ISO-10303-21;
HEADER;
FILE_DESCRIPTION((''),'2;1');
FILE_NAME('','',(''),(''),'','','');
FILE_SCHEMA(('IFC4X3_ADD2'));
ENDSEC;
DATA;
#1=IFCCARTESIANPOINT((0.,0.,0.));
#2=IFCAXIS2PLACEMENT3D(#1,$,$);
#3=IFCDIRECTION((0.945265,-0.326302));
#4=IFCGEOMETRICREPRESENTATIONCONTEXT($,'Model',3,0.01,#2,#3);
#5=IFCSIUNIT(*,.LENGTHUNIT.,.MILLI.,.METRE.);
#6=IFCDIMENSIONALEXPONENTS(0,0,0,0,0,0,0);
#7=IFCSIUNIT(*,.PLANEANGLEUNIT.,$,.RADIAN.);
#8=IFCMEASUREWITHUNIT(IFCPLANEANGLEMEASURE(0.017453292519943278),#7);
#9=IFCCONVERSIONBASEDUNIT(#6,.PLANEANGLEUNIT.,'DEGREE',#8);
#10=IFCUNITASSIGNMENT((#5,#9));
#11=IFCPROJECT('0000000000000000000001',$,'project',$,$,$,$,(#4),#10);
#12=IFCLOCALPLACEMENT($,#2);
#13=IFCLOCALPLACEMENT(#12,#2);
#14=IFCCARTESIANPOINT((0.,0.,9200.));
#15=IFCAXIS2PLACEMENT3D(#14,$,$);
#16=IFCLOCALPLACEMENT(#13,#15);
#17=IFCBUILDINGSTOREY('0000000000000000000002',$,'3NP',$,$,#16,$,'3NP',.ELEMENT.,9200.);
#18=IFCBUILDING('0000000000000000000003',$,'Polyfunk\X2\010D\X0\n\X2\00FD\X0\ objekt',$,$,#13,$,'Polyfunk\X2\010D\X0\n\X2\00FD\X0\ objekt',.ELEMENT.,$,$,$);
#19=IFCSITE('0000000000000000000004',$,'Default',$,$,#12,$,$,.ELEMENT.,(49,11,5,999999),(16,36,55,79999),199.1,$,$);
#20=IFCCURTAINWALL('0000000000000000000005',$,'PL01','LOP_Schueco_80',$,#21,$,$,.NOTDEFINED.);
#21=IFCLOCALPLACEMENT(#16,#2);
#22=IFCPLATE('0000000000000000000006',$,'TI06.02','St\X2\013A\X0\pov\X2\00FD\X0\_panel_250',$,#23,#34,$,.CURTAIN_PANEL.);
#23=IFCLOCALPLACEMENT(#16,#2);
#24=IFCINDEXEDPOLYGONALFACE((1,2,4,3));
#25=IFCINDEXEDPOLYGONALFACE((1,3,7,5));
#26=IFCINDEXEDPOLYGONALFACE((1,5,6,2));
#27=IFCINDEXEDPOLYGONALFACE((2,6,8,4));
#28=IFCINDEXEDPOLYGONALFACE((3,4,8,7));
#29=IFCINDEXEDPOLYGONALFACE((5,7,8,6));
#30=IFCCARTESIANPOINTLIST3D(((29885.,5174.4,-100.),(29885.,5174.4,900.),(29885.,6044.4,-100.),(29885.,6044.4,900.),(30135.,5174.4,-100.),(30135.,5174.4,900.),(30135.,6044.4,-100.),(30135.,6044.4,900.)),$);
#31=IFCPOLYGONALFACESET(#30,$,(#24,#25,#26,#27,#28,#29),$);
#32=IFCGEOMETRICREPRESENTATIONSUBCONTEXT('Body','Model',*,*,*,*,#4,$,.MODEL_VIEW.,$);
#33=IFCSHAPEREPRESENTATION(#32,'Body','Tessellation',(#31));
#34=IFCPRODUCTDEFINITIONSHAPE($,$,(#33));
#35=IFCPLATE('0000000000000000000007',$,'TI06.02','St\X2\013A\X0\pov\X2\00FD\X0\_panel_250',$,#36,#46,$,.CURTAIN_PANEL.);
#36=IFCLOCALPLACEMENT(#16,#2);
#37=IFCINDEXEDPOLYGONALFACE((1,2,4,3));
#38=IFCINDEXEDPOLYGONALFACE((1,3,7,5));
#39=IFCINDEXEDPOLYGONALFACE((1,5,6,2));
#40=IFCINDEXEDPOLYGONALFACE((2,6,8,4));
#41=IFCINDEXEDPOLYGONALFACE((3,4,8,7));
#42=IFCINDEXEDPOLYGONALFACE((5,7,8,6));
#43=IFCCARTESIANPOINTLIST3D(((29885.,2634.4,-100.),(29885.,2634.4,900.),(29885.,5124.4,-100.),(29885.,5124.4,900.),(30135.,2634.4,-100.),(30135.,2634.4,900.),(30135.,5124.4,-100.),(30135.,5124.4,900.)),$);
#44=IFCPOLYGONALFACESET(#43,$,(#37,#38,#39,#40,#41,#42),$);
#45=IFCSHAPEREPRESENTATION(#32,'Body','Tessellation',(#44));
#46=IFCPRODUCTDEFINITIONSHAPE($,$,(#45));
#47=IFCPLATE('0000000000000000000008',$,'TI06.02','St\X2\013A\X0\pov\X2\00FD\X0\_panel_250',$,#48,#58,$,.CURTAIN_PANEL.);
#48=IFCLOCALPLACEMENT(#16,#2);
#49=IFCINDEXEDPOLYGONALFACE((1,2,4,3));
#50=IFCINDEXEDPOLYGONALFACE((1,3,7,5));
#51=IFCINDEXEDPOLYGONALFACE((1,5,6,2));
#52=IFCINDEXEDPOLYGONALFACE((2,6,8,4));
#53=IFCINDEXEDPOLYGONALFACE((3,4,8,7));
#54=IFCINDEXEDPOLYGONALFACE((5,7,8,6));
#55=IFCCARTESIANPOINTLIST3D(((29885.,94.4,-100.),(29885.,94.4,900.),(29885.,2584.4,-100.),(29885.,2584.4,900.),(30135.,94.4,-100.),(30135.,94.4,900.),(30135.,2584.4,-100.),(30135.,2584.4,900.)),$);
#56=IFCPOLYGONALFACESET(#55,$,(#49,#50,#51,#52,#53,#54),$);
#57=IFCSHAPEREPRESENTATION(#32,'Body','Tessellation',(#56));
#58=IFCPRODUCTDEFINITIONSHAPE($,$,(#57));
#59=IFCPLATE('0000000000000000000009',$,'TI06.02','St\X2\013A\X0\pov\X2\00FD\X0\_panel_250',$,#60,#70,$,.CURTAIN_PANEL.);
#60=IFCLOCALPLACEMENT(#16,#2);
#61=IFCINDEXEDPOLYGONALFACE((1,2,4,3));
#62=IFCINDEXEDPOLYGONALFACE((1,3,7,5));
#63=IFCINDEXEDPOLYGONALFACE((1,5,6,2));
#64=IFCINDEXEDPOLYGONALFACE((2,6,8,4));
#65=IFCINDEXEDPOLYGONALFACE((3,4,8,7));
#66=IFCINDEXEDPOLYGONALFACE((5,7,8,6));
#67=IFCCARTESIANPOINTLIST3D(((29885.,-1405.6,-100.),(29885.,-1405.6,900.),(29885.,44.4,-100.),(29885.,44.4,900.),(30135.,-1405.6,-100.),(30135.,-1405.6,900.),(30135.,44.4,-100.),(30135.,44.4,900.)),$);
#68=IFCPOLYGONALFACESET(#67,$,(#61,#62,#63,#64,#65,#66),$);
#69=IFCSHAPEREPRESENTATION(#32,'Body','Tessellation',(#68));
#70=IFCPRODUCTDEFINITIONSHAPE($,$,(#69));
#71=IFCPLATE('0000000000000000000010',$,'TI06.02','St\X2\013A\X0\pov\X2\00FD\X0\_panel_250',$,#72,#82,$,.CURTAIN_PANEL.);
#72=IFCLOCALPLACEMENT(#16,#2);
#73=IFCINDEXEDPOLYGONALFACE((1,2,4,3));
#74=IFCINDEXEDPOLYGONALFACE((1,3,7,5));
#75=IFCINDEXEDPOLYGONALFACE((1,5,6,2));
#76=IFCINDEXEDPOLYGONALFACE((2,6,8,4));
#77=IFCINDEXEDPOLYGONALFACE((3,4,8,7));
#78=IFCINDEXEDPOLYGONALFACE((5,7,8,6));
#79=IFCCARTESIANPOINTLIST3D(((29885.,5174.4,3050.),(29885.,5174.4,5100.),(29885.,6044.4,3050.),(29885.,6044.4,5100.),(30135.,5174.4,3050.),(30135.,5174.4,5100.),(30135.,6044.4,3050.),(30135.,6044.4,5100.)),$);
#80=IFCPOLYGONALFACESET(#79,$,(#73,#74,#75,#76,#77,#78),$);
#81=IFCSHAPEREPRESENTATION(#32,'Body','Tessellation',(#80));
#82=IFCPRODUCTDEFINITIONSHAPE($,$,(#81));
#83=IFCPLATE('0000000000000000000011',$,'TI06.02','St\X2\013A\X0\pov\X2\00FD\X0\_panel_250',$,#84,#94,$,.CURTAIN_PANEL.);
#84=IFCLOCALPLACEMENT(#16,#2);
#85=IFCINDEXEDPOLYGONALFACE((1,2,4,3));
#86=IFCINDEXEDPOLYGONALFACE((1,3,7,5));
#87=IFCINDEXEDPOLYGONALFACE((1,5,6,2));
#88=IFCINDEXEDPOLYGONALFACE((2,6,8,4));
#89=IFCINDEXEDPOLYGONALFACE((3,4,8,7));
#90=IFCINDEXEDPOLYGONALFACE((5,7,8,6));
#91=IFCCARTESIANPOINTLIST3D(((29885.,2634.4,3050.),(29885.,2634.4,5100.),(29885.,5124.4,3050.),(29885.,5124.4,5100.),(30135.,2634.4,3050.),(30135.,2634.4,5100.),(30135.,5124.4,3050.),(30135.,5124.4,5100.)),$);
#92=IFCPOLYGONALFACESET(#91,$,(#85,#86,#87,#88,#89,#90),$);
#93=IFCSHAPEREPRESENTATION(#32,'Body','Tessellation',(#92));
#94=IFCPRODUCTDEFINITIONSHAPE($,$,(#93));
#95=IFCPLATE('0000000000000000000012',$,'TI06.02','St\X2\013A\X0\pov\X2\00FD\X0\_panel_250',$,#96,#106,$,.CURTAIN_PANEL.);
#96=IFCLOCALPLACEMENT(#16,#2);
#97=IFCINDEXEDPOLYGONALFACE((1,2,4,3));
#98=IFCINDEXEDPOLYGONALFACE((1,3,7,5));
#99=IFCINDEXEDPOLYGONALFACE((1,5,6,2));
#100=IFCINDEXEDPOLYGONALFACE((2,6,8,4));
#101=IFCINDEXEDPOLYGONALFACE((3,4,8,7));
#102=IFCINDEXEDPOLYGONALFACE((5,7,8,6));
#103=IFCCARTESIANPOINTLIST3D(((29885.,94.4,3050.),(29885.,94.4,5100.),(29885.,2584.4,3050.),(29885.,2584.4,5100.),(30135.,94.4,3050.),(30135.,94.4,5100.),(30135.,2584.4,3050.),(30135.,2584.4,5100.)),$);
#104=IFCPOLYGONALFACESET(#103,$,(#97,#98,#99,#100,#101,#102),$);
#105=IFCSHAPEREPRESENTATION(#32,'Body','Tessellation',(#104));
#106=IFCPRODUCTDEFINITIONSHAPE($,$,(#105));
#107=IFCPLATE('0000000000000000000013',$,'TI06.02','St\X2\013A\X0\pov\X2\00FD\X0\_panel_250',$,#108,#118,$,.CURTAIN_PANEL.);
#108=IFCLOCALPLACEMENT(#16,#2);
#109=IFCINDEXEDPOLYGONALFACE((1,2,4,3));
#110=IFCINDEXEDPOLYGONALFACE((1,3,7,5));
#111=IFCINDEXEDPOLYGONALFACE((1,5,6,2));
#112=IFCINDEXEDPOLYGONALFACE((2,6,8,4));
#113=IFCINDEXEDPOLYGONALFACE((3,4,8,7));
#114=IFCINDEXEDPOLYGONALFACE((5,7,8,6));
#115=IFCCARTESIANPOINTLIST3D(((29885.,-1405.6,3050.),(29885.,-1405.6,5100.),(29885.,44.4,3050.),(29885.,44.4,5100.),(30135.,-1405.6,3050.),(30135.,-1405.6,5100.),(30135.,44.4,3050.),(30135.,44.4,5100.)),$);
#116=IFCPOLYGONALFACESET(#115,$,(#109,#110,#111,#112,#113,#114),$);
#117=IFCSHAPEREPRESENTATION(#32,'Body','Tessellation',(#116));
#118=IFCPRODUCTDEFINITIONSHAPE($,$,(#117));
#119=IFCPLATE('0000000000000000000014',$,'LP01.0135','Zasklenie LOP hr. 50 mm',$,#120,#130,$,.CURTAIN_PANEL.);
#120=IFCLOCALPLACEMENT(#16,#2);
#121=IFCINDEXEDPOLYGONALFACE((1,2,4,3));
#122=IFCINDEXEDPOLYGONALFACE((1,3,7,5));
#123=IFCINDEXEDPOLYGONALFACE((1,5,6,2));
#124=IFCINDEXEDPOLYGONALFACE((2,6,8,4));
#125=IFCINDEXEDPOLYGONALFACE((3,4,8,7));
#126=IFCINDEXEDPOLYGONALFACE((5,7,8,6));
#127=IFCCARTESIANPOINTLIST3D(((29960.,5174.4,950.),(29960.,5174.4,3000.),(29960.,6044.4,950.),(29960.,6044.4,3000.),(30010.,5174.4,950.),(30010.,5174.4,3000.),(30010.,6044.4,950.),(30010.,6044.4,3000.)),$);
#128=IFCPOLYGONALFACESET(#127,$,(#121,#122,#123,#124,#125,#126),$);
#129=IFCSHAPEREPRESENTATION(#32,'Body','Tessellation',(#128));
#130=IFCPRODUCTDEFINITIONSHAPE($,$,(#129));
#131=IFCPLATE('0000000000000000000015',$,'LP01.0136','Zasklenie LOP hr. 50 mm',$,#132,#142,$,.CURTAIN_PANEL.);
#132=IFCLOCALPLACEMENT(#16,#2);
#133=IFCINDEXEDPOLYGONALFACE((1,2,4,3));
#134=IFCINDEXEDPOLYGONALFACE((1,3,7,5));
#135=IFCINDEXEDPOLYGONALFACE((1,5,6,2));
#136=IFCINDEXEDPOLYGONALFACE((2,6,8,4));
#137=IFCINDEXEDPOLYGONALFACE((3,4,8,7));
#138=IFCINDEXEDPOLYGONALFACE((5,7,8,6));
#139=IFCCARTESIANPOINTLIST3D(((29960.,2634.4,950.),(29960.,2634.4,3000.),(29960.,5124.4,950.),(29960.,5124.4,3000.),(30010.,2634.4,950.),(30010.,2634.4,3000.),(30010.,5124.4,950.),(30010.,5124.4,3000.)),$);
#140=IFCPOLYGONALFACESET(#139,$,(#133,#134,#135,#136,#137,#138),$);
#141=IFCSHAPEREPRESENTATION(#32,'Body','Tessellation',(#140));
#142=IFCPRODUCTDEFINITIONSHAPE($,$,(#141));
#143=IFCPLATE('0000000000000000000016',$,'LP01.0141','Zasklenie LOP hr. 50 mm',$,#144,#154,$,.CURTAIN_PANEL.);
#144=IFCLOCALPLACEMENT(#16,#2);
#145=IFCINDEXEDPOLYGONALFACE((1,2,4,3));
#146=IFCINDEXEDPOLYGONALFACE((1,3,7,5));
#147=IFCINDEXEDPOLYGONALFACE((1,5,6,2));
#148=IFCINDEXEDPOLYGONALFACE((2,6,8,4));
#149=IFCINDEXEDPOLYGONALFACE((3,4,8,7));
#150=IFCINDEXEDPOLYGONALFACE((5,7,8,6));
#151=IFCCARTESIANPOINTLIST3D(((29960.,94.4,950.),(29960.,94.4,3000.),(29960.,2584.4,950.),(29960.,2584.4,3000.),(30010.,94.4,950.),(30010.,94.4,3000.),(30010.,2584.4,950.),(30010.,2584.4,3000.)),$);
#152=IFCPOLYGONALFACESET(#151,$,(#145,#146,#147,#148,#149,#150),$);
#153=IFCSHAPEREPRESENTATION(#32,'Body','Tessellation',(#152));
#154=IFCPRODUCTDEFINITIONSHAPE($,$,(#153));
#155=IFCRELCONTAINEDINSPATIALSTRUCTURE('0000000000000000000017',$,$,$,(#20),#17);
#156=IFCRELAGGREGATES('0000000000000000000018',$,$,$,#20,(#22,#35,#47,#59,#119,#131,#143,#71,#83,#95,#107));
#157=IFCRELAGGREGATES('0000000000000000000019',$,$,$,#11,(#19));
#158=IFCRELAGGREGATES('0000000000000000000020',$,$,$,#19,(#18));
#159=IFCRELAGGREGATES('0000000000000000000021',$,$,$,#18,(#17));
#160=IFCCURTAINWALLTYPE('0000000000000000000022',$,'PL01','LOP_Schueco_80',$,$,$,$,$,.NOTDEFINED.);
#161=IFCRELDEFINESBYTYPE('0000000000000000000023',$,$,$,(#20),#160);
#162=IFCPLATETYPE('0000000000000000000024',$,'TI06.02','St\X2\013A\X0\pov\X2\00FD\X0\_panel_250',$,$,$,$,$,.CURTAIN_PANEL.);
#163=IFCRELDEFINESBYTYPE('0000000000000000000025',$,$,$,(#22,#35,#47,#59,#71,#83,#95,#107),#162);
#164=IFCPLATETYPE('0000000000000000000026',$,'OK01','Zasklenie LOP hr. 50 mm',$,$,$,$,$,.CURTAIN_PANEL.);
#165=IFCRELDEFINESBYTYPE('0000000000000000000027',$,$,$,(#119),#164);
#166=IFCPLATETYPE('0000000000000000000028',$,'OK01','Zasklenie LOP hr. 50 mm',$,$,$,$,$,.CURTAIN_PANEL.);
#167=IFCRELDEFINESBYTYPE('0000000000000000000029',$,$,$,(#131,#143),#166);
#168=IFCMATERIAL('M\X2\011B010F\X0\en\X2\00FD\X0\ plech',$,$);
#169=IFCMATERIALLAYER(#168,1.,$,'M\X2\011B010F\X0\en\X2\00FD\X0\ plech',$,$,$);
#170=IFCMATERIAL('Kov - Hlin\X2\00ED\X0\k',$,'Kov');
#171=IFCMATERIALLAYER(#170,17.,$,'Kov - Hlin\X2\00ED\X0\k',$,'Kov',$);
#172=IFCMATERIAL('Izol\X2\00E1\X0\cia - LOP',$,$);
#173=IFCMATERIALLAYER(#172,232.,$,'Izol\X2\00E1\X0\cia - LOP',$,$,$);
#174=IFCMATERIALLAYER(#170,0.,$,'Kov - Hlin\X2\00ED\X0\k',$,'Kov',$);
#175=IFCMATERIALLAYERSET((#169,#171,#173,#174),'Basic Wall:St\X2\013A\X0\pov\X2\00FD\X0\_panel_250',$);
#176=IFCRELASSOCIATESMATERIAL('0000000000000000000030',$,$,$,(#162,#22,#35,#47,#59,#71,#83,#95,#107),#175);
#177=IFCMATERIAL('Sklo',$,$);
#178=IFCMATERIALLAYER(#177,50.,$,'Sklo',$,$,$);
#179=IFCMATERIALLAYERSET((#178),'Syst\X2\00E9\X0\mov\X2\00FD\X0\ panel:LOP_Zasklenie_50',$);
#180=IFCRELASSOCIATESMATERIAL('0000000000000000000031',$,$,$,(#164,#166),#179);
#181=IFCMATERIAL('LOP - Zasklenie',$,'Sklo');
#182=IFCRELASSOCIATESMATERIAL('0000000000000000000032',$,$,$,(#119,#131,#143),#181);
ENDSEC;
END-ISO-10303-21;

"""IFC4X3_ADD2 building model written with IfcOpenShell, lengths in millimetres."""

from ifc_helpers import new_model, entity, si_unit, converted_unit, direction, frame, frame_2d, origin, origin_2d_with_axis, place, context, subcontext, project, spatial, rectangle, extrude, source, transform, mapped, material, layer, layer_set, layer_usage, type_object, type_shapes, element, aggregate, save


model = new_model("IFC4X3_ADD2")

# Units and contexts
model_context = context("Model", 3, precision=0.01, world=origin(), true_north=direction((0.945265, -0.326302)))
body_context = subcontext(model_context, "Body", "Model", "MODEL_VIEW")
ifc_project = project(units=[si_unit("LENGTHUNIT", "METRE", prefix="MILLI"), converted_unit("PLANEANGLEUNIT", "DEGREE", entity("IfcPlaneAngleMeasure", 0.017453292519943278), si_unit("PLANEANGLEUNIT", "RADIAN"), dimensions=[0, 0, 0, 0, 0, 0, 0])], contexts=[model_context])

# Site, building, storey
site_placement = place(None, origin())
site = spatial("IfcSite", under=ifc_project, at=site_placement, Name="Default", CompositionType="ELEMENT", RefLatitude=(49, 11, 5, 999999), RefLongitude=(16, 36, 55, 79999), RefElevation=199.1)
building_placement = place(site_placement, origin())
building = spatial("IfcBuilding", under=site, at=building_placement, Name="Polyfunkčný objekt", LongName="Polyfunkčný objekt", CompositionType="ELEMENT")
storey_placement = place(building_placement, frame((0.0, 0.0, 9200.0)))
storey = spatial("IfcBuildingStorey", under=building, at=storey_placement, Name="3NP", LongName="3NP", CompositionType="ELEMENT", Elevation=9200.0)

# Curtain wall
curtain_wall_type = type_object("IfcCurtainWallType", Name="PL01", Description="LOP_Schueco_80", PredefinedType="NOTDEFINED")
curtain_wall_1_placement = place(storey_placement, frame((0.0, 0.0, -9200.0)))
curtain_wall_1 = element("IfcCurtainWall", 1, at=curtain_wall_1_placement, inside=storey, type_object=curtain_wall_type, Name="PL01", Description="LOP_Schueco_80", PredefinedType="NOTDEFINED")

# Plates
ifc_material_1 = material(Name="Měďený plech")
ifc_layer_1 = layer(ifc_material_1, 1.0, Name="Měďený plech")
ifc_material_2 = material(Name="Kov - Hliník", Category="Kov")
ifc_layer_2 = layer(ifc_material_2, 17.0, Name="Kov - Hliník", Category="Kov")
ifc_material_3 = material(Name="Izolácia - LOP")
ifc_layer_3 = layer(ifc_material_3, 232.0, Name="Izolácia - LOP")
ifc_layer_4 = layer(ifc_material_2, 0.0, Name="Kov - Hliník", Category="Kov")
ifc_layer_set_1 = layer_set([ifc_layer_1, ifc_layer_2, ifc_layer_3, ifc_layer_4], Name="Basic Wall:Stĺpový_panel_250")
ifc_layer_usage_1 = layer_usage(ifc_layer_set_1, "AXIS2", "POSITIVE", -125.0)
plate_type_1 = type_object("IfcPlateType", Name="TI06.02", Description="Stĺpový_panel_250", PredefinedType="CURTAIN_PANEL", material=ifc_layer_set_1)
plate_1_placement = place(storey_placement, frame((30010.0, 6044.4, -100.0), z_axis=(0.0, 0.0, 1.0), x_axis=(0.0, -1.0, 0.0)))
plate_1 = element("IfcPlate", 2, at=plate_1_placement, type_object=plate_type_1, material=ifc_layer_usage_1, Name="TI06.02", Description="Stĺpový_panel_250", PredefinedType="CURTAIN_PANEL", context=body_context, shape_type="SweptSolid", body=[
    extrude(rectangle(XDim=250.0, YDim=870.0, at=frame_2d((0.0, 0.0), x_axis=(1.0, 0.0))), frame((435.0, 0.0, 0.0), z_axis=(0.0, 0.0, 1.0), x_axis=(0.0, 1.0, 0.0)), (0.0, 0.0, 1.0), 1000.0),
])
ifc_layer_usage_2 = layer_usage(ifc_layer_set_1, "AXIS2", "POSITIVE", -125.0)
plate_2_placement = place(storey_placement, frame((30010.0, 5124.4, -100.0), z_axis=(0.0, 0.0, 1.0), x_axis=(0.0, -1.0, 0.0)))
plate_2 = element("IfcPlate", 3, at=plate_2_placement, type_object=plate_type_1, material=ifc_layer_usage_2, Name="TI06.02", Description="Stĺpový_panel_250", PredefinedType="CURTAIN_PANEL", context=body_context, shape_type="SweptSolid", body=[
    extrude(rectangle(XDim=250.0, YDim=2490.0, at=frame_2d((0.0, 0.0), x_axis=(1.0, 0.0))), frame((1245.0, 0.0, 0.0), z_axis=(0.0, 0.0, 1.0), x_axis=(0.0, 1.0, 0.0)), (0.0, 0.0, 1.0), 1000.0),
])
ifc_layer_usage_3 = layer_usage(ifc_layer_set_1, "AXIS2", "POSITIVE", -125.0)
plate_3_placement = place(storey_placement, frame((30010.0, 2584.4, -100.0), z_axis=(0.0, 0.0, 1.0), x_axis=(0.0, -1.0, 0.0)))
plate_3 = element("IfcPlate", 4, at=plate_3_placement, type_object=plate_type_1, material=ifc_layer_usage_3, Name="TI06.02", Description="Stĺpový_panel_250", PredefinedType="CURTAIN_PANEL", context=body_context, shape_type="SweptSolid", body=[
    extrude(rectangle(XDim=250.0, YDim=2490.0, at=frame_2d((0.0, 0.0), x_axis=(1.0, 0.0))), frame((1245.0, 0.0, 0.0), z_axis=(0.0, 0.0, 1.0), x_axis=(0.0, 1.0, 0.0)), (0.0, 0.0, 1.0), 1000.0),
])
ifc_layer_usage_4 = layer_usage(ifc_layer_set_1, "AXIS2", "POSITIVE", -125.0)
plate_4_placement = place(storey_placement, frame((30010.0, 44.4, -100.0), z_axis=(0.0, 0.0, 1.0), x_axis=(0.0, -1.0, 0.0)))
plate_4 = element("IfcPlate", 5, at=plate_4_placement, type_object=plate_type_1, material=ifc_layer_usage_4, Name="TI06.02", Description="Stĺpový_panel_250", PredefinedType="CURTAIN_PANEL", context=body_context, shape_type="SweptSolid", body=[
    extrude(rectangle(XDim=250.0, YDim=1450.0, at=frame_2d((0.0, 0.0), x_axis=(1.0, 0.0))), frame((725.0, 0.0, 0.0), z_axis=(0.0, 0.0, 1.0), x_axis=(0.0, 1.0, 0.0)), (0.0, 0.0, 1.0), 1000.0),
])
ifc_layer_usage_5 = layer_usage(ifc_layer_set_1, "AXIS2", "POSITIVE", -125.0)
plate_5_placement = place(storey_placement, frame((30010.0, 6044.4, 3050.0), z_axis=(0.0, 0.0, 1.0), x_axis=(0.0, -1.0, 0.0)))
plate_5 = element("IfcPlate", 6, at=plate_5_placement, type_object=plate_type_1, material=ifc_layer_usage_5, Name="TI06.02", Description="Stĺpový_panel_250", PredefinedType="CURTAIN_PANEL", context=body_context, shape_type="SweptSolid", body=[
    extrude(rectangle(XDim=250.0, YDim=870.0, at=frame_2d((0.0, 0.0), x_axis=(1.0, 0.0))), frame((435.0, 0.0, 0.0), z_axis=(0.0, 0.0, 1.0), x_axis=(0.0, 1.0, 0.0)), (0.0, 0.0, 1.0), 2050.0),
])
ifc_layer_usage_6 = layer_usage(ifc_layer_set_1, "AXIS2", "POSITIVE", -125.0)
plate_6_placement = place(storey_placement, frame((30010.0, 5124.4, 3050.0), z_axis=(0.0, 0.0, 1.0), x_axis=(0.0, -1.0, 0.0)))
plate_6 = element("IfcPlate", 7, at=plate_6_placement, type_object=plate_type_1, material=ifc_layer_usage_6, Name="TI06.02", Description="Stĺpový_panel_250", PredefinedType="CURTAIN_PANEL", context=body_context, shape_type="SweptSolid", body=[
    extrude(rectangle(XDim=250.0, YDim=2490.0, at=frame_2d((0.0, 0.0), x_axis=(1.0, 0.0))), frame((1245.0, 0.0, 0.0), z_axis=(0.0, 0.0, 1.0), x_axis=(0.0, 1.0, 0.0)), (0.0, 0.0, 1.0), 2050.0),
])
ifc_layer_usage_7 = layer_usage(ifc_layer_set_1, "AXIS2", "POSITIVE", -125.0)
plate_7_placement = place(storey_placement, frame((30010.0, 2584.4, 3050.0), z_axis=(0.0, 0.0, 1.0), x_axis=(0.0, -1.0, 0.0)))
plate_7 = element("IfcPlate", 8, at=plate_7_placement, type_object=plate_type_1, material=ifc_layer_usage_7, Name="TI06.02", Description="Stĺpový_panel_250", PredefinedType="CURTAIN_PANEL", context=body_context, shape_type="SweptSolid", body=[
    extrude(rectangle(XDim=250.0, YDim=2490.0, at=frame_2d((0.0, 0.0), x_axis=(1.0, 0.0))), frame((1245.0, 0.0, 0.0), z_axis=(0.0, 0.0, 1.0), x_axis=(0.0, 1.0, 0.0)), (0.0, 0.0, 1.0), 2050.0),
])
ifc_layer_usage_8 = layer_usage(ifc_layer_set_1, "AXIS2", "POSITIVE", -125.0)
plate_8_placement = place(storey_placement, frame((30010.0, 44.4, 3050.0), z_axis=(0.0, 0.0, 1.0), x_axis=(0.0, -1.0, 0.0)))
plate_8 = element("IfcPlate", 9, at=plate_8_placement, type_object=plate_type_1, material=ifc_layer_usage_8, Name="TI06.02", Description="Stĺpový_panel_250", PredefinedType="CURTAIN_PANEL", context=body_context, shape_type="SweptSolid", body=[
    extrude(rectangle(XDim=250.0, YDim=1450.0, at=frame_2d((0.0, 0.0), x_axis=(1.0, 0.0))), frame((725.0, 0.0, 0.0), z_axis=(0.0, 0.0, 1.0), x_axis=(0.0, 1.0, 0.0)), (0.0, 0.0, 1.0), 2050.0),
])
ifc_material_4 = material(Name="LOP - Zasklenie", Category="Sklo")
ifc_material_5 = material(Name="Sklo")
ifc_layer_5 = layer(ifc_material_5, 50.0, Name="Sklo")
ifc_layer_set_2 = layer_set([ifc_layer_5], Name="Systémový panel:LOP_Zasklenie_50")
plate_type_2 = type_object("IfcPlateType", Name="OK01", Description="Zasklenie LOP hr. 50 mm", PredefinedType="CURTAIN_PANEL", material=ifc_layer_set_2)
shared_shape_1 = source(origin(), body_context, "Body", "SweptSolid", [
    extrude(rectangle(XDim=50.0, YDim=870.0, at=origin_2d_with_axis()), frame((0.0, -25.0, 0.0), z_axis=(0.0, 0.0, 1.0), x_axis=(0.0, 1.0, 0.0)), (0.0, 0.0, 1.0), 2050.0),
])
type_shapes(plate_type_2, [shared_shape_1])
plate_9_placement = place(curtain_wall_1_placement, frame((30010.0, 5609.4, 10150.0), z_axis=(0.0, 0.0, 1.0), x_axis=(0.0, -1.0, 0.0)))
plate_9 = element("IfcPlate", 10, at=plate_9_placement, type_object=plate_type_2, material=ifc_material_4, Name="LP01.0135", Description="Zasklenie LOP hr. 50 mm", PredefinedType="CURTAIN_PANEL", context=body_context, shape_type="MappedRepresentation", body=[
    mapped(shared_shape_1, transform((0.0, 0.0, 0.0), scale=1.0)),
])
plate_type_3 = type_object("IfcPlateType", Name="OK01", Description="Zasklenie LOP hr. 50 mm", PredefinedType="CURTAIN_PANEL", material=ifc_layer_set_2)
shared_shape_2 = source(origin(), body_context, "Body", "SweptSolid", [
    extrude(rectangle(XDim=50.0, YDim=2490.0, at=origin_2d_with_axis()), frame((0.0, -25.0, 0.0), z_axis=(0.0, 0.0, 1.0), x_axis=(0.0, 1.0, 0.0)), (0.0, 0.0, 1.0), 2050.0),
])
type_shapes(plate_type_3, [shared_shape_2])
plate_10_placement = place(curtain_wall_1_placement, frame((30010.0, 3879.4, 10150.0), z_axis=(0.0, 0.0, 1.0), x_axis=(0.0, -1.0, 0.0)))
plate_10 = element("IfcPlate", 11, at=plate_10_placement, type_object=plate_type_3, material=ifc_material_4, Name="LP01.0136", Description="Zasklenie LOP hr. 50 mm", PredefinedType="CURTAIN_PANEL", context=body_context, shape_type="MappedRepresentation", body=[
    mapped(shared_shape_2, transform((0.0, 0.0, 0.0), scale=1.0)),
])
plate_11_placement = place(curtain_wall_1_placement, frame((30010.0, 1339.4, 10150.0), z_axis=(0.0, 0.0, 1.0), x_axis=(0.0, -1.0, 0.0)))
plate_11 = element("IfcPlate", 12, at=plate_11_placement, type_object=plate_type_3, material=ifc_material_4, Name="LP01.0141", Description="Zasklenie LOP hr. 50 mm", PredefinedType="CURTAIN_PANEL", context=body_context, shape_type="MappedRepresentation", body=[
    mapped(shared_shape_2, transform((0.0, 0.0, 0.0), scale=1.0)),
])
aggregate(curtain_wall_1, [plate_1, plate_2, plate_3, plate_4, plate_9, plate_10, plate_11, plate_5, plate_6, plate_7, plate_8])

save(model, "model.ifc")
